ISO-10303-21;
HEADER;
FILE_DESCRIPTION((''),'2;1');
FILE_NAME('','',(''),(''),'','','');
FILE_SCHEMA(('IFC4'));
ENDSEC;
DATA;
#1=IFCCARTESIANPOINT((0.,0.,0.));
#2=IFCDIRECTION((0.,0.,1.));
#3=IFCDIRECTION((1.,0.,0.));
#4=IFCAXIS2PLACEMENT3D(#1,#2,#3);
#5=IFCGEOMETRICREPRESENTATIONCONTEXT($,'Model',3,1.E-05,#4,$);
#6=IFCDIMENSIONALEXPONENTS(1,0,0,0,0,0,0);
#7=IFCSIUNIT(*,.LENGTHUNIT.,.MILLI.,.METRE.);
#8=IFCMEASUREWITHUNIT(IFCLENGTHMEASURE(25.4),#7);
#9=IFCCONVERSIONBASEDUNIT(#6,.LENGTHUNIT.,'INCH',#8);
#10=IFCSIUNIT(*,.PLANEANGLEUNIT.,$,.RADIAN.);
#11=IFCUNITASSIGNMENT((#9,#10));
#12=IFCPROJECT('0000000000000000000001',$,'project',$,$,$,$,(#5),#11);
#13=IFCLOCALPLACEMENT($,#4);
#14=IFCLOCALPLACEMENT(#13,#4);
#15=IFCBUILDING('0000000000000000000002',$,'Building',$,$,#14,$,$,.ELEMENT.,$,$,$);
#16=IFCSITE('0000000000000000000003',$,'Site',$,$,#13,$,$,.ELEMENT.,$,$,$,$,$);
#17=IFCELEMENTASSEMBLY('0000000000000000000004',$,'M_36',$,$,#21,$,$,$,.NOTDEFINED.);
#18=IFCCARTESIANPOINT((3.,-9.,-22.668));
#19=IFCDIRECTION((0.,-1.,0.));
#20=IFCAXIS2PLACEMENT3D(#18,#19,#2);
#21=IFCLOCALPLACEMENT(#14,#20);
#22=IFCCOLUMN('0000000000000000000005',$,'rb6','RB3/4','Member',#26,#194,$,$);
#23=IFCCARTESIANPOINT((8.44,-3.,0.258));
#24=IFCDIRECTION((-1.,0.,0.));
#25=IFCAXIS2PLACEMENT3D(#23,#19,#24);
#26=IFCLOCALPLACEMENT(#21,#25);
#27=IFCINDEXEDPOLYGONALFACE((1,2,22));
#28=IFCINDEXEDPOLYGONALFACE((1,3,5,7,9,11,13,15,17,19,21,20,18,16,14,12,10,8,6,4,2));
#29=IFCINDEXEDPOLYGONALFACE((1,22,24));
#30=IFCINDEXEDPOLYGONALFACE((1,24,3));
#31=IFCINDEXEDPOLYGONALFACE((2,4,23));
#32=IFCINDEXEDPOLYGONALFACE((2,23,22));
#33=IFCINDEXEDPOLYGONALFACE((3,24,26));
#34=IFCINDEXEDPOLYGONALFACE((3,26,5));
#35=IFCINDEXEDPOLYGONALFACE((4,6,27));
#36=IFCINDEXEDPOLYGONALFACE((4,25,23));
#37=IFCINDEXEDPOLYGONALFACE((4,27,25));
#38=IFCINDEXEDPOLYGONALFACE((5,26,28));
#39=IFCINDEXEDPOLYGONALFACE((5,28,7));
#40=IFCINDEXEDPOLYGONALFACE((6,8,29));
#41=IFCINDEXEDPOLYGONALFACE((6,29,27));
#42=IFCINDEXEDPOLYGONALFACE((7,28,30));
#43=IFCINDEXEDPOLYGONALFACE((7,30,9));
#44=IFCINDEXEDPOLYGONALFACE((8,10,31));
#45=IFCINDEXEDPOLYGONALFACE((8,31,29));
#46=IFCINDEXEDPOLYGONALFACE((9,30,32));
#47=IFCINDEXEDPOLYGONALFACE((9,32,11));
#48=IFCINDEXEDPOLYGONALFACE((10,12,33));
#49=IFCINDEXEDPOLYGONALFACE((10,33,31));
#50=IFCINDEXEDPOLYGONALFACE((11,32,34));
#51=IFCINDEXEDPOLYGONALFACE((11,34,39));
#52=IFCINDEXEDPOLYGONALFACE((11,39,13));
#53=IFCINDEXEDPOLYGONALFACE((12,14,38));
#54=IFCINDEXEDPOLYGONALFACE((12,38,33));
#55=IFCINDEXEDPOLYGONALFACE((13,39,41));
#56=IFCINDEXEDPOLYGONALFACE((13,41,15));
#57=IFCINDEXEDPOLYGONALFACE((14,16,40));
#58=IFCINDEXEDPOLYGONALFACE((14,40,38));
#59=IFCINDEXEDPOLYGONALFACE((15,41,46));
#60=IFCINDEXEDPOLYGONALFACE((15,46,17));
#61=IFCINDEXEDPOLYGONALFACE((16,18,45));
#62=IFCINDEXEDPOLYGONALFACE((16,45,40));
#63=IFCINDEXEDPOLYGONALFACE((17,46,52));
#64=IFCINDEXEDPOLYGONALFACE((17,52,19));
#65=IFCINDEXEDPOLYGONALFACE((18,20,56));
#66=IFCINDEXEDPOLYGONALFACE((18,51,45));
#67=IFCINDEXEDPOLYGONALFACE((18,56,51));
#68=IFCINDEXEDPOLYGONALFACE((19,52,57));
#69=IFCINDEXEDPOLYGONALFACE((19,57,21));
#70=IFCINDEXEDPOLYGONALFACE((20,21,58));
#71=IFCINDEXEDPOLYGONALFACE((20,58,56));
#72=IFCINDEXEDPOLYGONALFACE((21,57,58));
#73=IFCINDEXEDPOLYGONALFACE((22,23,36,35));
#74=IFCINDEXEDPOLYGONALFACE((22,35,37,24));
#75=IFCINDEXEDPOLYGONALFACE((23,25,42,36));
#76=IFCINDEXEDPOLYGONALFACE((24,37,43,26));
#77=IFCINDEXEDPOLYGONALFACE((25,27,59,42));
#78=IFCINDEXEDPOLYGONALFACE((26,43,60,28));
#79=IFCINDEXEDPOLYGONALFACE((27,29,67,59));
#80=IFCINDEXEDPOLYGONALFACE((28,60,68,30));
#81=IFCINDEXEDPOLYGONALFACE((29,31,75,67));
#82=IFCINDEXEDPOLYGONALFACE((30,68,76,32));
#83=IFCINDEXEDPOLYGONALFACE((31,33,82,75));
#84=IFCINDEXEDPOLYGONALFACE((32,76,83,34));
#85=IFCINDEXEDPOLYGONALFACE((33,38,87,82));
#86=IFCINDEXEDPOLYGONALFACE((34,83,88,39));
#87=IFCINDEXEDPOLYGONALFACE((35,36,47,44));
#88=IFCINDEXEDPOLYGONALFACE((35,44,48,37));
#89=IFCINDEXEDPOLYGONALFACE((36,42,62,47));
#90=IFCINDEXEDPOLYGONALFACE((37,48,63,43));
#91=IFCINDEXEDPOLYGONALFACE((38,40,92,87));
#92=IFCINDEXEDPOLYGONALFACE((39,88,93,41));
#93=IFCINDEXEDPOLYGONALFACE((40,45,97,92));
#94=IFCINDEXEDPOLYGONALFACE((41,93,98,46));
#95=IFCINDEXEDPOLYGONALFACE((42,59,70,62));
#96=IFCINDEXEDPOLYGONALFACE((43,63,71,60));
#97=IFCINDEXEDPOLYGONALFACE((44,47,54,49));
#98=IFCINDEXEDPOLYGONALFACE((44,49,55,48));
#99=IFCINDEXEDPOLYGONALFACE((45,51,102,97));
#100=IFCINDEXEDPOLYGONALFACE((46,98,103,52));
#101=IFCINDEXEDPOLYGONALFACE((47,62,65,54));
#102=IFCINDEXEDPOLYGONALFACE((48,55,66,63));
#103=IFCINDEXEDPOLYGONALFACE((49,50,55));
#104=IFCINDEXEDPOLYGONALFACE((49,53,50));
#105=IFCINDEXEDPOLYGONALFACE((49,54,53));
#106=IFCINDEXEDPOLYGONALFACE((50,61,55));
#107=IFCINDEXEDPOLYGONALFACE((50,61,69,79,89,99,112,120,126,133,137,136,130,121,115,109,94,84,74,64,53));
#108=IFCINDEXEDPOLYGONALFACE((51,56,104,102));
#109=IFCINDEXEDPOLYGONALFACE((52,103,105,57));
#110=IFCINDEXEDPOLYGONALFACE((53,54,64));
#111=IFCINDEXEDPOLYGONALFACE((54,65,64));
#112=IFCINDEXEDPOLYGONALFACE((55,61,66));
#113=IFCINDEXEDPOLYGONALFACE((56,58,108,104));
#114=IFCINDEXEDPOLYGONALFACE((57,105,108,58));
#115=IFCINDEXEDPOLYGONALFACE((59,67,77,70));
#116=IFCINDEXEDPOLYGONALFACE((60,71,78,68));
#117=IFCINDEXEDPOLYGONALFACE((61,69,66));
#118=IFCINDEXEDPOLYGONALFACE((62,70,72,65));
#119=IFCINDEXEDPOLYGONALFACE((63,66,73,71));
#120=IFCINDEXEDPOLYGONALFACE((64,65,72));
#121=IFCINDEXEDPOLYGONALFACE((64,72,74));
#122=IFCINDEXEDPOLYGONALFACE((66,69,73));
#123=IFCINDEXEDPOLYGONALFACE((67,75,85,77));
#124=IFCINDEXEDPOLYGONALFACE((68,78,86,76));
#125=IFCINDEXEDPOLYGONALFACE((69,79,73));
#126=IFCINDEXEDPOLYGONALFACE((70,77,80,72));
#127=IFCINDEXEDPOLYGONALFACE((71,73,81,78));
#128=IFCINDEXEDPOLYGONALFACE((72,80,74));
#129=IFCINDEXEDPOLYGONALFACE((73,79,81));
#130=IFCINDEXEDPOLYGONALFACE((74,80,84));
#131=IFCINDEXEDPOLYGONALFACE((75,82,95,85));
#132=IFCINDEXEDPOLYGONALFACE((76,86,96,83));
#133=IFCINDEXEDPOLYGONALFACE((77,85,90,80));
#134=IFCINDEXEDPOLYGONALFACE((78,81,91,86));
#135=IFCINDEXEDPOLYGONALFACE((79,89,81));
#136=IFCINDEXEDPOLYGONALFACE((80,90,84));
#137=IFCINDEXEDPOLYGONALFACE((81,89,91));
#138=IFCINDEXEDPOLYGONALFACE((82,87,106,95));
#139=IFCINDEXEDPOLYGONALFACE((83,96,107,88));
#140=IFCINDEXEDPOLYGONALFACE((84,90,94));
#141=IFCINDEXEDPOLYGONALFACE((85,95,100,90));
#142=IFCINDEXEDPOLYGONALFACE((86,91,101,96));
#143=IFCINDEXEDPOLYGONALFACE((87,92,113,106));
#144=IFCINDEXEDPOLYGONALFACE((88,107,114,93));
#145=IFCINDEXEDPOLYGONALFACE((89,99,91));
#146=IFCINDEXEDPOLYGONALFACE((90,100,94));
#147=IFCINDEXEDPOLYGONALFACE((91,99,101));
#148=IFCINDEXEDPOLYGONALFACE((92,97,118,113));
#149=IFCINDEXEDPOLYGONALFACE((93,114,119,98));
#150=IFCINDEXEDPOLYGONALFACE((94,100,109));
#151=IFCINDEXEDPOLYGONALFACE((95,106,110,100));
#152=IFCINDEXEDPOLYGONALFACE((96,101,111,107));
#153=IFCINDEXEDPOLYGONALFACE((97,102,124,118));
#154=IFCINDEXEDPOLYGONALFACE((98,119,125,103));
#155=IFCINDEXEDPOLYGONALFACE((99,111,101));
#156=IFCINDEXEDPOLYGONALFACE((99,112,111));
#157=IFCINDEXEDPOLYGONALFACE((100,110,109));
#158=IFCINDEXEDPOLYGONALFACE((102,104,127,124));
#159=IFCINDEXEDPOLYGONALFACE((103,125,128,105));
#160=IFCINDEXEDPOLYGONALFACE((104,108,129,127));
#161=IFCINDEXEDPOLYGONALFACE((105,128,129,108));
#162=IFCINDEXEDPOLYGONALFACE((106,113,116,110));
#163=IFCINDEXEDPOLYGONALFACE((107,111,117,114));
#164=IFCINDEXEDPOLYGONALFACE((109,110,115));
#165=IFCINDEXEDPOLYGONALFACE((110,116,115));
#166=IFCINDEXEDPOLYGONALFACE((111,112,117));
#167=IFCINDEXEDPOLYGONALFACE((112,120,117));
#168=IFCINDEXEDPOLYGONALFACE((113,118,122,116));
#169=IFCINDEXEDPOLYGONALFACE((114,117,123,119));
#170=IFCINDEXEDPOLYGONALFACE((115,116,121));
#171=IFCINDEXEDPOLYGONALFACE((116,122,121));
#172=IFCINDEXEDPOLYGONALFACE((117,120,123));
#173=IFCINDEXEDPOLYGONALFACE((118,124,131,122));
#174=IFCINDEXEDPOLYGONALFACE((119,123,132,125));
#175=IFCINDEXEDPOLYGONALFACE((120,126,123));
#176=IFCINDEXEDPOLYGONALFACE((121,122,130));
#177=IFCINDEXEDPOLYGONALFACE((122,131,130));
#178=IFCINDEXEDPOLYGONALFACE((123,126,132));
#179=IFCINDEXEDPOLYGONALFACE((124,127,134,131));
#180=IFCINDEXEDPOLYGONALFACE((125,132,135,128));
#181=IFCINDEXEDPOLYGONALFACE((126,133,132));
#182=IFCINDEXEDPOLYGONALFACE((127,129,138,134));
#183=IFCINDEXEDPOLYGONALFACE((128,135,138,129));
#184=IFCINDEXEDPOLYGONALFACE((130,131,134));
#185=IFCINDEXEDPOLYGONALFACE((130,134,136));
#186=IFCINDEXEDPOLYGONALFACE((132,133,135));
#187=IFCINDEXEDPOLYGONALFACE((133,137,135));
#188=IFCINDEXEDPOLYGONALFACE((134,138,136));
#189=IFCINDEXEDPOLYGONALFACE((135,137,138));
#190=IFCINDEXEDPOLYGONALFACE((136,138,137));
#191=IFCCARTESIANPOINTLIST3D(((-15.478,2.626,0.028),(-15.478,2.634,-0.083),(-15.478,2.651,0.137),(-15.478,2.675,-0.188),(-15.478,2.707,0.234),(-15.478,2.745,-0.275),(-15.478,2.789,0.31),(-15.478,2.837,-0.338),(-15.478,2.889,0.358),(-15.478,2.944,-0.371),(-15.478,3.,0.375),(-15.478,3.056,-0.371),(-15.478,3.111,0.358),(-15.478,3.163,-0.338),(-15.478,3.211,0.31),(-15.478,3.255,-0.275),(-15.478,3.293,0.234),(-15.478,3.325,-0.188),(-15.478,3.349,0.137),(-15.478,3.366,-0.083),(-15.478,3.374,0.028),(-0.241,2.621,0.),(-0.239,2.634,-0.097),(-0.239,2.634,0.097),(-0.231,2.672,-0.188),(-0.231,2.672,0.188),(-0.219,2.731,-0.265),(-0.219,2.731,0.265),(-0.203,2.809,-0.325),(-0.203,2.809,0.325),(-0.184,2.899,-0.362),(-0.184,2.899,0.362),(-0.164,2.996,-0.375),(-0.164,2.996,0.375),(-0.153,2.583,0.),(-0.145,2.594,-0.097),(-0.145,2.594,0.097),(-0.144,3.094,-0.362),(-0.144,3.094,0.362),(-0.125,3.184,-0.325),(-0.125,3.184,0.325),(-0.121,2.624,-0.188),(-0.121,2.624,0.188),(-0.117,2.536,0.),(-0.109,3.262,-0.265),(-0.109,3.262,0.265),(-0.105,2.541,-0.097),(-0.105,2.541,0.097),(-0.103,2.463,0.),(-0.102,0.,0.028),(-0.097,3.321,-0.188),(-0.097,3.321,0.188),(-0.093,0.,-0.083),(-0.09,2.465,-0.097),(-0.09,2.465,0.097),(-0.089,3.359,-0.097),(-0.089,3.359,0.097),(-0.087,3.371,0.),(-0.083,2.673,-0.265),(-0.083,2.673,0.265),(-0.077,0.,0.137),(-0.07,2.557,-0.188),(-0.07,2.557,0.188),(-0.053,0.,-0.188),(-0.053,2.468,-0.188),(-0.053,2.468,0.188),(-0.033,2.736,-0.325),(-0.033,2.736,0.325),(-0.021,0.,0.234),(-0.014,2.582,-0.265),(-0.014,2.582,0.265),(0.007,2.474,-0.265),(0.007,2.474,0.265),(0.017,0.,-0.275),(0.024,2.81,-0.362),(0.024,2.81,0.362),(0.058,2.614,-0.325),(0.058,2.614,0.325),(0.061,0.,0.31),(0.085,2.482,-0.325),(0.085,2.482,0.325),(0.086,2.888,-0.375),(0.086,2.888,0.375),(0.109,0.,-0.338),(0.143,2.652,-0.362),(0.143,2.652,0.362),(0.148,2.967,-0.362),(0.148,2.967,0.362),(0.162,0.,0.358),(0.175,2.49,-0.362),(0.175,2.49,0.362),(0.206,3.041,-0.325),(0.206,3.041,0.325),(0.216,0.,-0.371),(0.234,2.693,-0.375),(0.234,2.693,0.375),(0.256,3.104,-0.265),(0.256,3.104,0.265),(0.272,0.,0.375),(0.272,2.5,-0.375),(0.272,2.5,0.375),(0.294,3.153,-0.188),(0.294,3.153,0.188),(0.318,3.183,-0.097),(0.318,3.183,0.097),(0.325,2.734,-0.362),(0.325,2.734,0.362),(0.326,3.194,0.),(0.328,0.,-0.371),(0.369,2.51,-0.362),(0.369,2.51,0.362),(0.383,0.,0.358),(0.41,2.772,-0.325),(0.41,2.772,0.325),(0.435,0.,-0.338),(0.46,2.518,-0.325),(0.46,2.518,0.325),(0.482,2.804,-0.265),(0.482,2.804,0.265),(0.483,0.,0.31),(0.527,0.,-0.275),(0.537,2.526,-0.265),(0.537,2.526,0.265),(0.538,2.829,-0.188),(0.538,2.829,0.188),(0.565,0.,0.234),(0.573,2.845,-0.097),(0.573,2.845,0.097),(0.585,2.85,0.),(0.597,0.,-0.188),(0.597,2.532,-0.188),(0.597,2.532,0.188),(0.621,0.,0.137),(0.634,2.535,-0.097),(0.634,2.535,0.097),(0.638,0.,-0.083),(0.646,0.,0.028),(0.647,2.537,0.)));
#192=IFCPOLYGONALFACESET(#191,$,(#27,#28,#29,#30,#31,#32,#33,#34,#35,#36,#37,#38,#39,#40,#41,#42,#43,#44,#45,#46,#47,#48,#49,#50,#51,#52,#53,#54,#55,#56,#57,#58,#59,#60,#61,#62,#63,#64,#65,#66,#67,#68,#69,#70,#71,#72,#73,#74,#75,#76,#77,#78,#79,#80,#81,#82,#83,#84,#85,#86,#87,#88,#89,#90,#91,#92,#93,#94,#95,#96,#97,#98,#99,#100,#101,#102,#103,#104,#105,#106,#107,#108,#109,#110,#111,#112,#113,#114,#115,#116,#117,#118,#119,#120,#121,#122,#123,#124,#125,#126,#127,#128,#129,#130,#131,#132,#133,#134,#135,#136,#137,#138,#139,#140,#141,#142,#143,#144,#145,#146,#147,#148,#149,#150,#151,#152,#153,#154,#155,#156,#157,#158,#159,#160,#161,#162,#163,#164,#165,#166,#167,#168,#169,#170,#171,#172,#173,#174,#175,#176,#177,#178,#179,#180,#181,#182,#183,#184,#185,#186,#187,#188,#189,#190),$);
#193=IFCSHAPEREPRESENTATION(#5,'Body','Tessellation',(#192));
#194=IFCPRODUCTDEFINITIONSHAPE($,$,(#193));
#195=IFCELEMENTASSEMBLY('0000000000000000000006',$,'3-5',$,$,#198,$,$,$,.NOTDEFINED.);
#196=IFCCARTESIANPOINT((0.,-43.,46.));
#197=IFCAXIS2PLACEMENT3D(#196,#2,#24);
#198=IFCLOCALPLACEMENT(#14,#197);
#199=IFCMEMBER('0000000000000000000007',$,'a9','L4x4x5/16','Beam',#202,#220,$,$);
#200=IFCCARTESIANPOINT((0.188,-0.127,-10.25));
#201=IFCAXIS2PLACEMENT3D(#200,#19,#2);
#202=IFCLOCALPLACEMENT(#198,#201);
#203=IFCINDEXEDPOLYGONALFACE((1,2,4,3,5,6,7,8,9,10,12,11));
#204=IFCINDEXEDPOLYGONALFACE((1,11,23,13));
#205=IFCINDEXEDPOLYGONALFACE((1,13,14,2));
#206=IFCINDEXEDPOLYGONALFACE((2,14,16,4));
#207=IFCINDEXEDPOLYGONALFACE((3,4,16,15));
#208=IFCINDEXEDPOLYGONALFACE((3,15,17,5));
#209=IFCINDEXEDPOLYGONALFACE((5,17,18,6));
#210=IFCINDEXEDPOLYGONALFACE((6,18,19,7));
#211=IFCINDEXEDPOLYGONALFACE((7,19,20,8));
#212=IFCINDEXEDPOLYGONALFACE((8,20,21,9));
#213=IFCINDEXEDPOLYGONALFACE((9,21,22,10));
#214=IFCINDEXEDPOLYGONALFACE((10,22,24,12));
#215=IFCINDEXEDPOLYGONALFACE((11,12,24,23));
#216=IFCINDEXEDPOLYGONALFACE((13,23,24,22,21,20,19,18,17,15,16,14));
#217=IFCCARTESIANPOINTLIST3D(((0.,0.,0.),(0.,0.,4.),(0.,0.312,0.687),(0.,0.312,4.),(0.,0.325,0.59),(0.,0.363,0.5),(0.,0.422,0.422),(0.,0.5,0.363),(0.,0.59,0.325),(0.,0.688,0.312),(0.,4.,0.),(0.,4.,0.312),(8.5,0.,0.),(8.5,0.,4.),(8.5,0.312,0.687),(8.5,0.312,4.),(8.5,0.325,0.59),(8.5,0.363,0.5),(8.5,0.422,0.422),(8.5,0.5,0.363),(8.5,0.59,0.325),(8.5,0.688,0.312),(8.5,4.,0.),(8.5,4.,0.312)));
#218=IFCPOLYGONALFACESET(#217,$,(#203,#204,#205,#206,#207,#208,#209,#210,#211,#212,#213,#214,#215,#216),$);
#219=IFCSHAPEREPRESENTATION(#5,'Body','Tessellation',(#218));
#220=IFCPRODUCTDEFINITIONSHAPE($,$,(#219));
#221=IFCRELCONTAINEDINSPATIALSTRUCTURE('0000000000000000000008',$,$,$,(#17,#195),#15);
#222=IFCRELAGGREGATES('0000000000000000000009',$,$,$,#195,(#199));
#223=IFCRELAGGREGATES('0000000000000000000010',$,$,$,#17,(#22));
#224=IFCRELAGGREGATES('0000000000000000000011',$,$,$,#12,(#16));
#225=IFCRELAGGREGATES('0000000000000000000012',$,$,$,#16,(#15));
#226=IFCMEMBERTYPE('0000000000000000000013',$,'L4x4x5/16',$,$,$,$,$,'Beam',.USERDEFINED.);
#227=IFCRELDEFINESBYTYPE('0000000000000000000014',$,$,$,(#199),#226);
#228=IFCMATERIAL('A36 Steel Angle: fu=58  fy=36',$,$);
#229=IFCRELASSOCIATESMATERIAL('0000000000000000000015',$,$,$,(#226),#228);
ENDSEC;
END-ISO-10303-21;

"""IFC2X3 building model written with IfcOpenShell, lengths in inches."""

from ifc_helpers import new_model, entity, si_unit, converted_unit, frame, frame_2d, origin_with_axes, place, context, project, spatial, l_section, transform_2d, derived_profile, extrude, source, transform, mapped, material, type_object, type_shapes, element, aggregate, save


model = new_model("IFC2X3")

# Units and contexts
model_context = context("Model", 3, precision=1e-05, world=origin_with_axes())
ifc_project = project(units=[converted_unit("LENGTHUNIT", "INCH", entity("IfcLengthMeasure", 25.4), si_unit("LENGTHUNIT", "METRE", prefix="MILLI"), dimensions=[1, 0, 0, 0, 0, 0, 0]), si_unit("PLANEANGLEUNIT", "RADIAN")], contexts=[model_context])

# Site, building
site_placement = place(None, origin_with_axes())
site = spatial("IfcSite", under=ifc_project, at=site_placement, Name="Site", CompositionType="ELEMENT")
building_placement = place(site_placement, origin_with_axes())
building = spatial("IfcBuilding", under=site, at=building_placement, Name="Building", CompositionType="ELEMENT")

# Element assembly, column
assembly_1_placement = place(building_placement, frame((3.0, -9.0, -22.668), z_axis=(0.0, -1.0, 0.0), x_axis=(0.0, 0.0, 1.0)))
assembly_1 = element("IfcElementAssembly", 1, at=assembly_1_placement, inside=building, Name="M_36", PredefinedType="NOTDEFINED")
column_placement = place(assembly_1_placement, frame((8.44, -3.0, 0.258), z_axis=(0.0, -1.0, 0.0), x_axis=(-1.0, 0.0, 0.0)))
cartesian_point = entity("IfcCartesianPoint", [0.0, 0.0, 0.0])
ifc_direction_1 = entity("IfcDirection", [0.0, 0.0, 1.0])
ifc_direction_2 = entity("IfcDirection", [1.0, 0.0, 0.0])
column = element("IfcColumn", 2, at=column_placement, Name="rb6", Description="RB3/4", ObjectType="Member", context=model_context, shape_type="SweptSolid", body=[
    entity("IfcSurfaceCurveSweptAreaSolid", entity("IfcCircleProfileDef", "AREA", None, entity("IfcAxis2Placement2D", entity("IfcCartesianPoint", [0.0, 0.0]), entity("IfcDirection", [1.0, 0.0])), 0.375), entity("IfcAxis2Placement3D", cartesian_point, ifc_direction_1, ifc_direction_2), entity("IfcPolyline", [entity("IfcCartesianPoint", [0.272, 0.0]), entity("IfcCartesianPoint", [0.272, 2.5]), entity("IfcCartesianPoint", [0.234, 2.693]), entity("IfcCartesianPoint", [0.086, 2.888]), entity("IfcCartesianPoint", [-0.164, 2.996]), entity("IfcCartesianPoint", [-15.478, 3.0])]), 0.0, 1.0, entity("IfcPlane", entity("IfcAxis2Placement3D", cartesian_point, ifc_direction_1, ifc_direction_2))),
])

# Element assembly, member
assembly_2_placement = place(building_placement, frame((0.0, -43.0, 46.0), z_axis=(0.0, 0.0, 1.0), x_axis=(-1.0, 0.0, 0.0)))
assembly_2 = element("IfcElementAssembly", 3, at=assembly_2_placement, inside=building, Name="3-5", PredefinedType="NOTDEFINED")
ifc_material_1 = material(Name="A36 Steel Angle: fu=58  fy=36")
member_type_1 = type_object("IfcMemberType", Name="L4x4x5/16", ElementType="Beam", PredefinedType="USERDEFINED", material=ifc_material_1)
shared_shape_1 = source(origin_with_axes(), model_context, "Body", "SweptSolid", [
    extrude(derived_profile(l_section(Depth=4.0, Width=4.0, Thickness=0.312, FilletRadius=0.375, at=frame_2d((2.0, 2.0), x_axis=(1.0, 0.0))), transform_2d((0.0, 0.0), x_axis=(-1.0, 0.0), y_axis=(0.0, 1.0))), frame((0.0, 0.0, 0.0), z_axis=(1.0, 0.0, 0.0), x_axis=(0.0, 1.0, 0.0)), (0.0, 0.0, 1.0), 8.5),
])
type_shapes(member_type_1, [shared_shape_1])
member_1_placement = place(assembly_2_placement, frame((0.188, -0.127, -10.25), z_axis=(0.0, -1.0, 0.0), x_axis=(0.0, 0.0, 1.0)))
member_1 = element("IfcMember", 4, at=member_1_placement, type_object=member_type_1, Name="a9", Description="L4x4x5/16", ObjectType="Beam", context=model_context, shape_type="MappedRepresentation", body=[
    mapped(shared_shape_1, transform((0.0, 0.0, 0.0), scale=1.0)),
])
aggregate(assembly_2, [member_1])

aggregate(assembly_1, [column])

save(model, "model.ifc")
